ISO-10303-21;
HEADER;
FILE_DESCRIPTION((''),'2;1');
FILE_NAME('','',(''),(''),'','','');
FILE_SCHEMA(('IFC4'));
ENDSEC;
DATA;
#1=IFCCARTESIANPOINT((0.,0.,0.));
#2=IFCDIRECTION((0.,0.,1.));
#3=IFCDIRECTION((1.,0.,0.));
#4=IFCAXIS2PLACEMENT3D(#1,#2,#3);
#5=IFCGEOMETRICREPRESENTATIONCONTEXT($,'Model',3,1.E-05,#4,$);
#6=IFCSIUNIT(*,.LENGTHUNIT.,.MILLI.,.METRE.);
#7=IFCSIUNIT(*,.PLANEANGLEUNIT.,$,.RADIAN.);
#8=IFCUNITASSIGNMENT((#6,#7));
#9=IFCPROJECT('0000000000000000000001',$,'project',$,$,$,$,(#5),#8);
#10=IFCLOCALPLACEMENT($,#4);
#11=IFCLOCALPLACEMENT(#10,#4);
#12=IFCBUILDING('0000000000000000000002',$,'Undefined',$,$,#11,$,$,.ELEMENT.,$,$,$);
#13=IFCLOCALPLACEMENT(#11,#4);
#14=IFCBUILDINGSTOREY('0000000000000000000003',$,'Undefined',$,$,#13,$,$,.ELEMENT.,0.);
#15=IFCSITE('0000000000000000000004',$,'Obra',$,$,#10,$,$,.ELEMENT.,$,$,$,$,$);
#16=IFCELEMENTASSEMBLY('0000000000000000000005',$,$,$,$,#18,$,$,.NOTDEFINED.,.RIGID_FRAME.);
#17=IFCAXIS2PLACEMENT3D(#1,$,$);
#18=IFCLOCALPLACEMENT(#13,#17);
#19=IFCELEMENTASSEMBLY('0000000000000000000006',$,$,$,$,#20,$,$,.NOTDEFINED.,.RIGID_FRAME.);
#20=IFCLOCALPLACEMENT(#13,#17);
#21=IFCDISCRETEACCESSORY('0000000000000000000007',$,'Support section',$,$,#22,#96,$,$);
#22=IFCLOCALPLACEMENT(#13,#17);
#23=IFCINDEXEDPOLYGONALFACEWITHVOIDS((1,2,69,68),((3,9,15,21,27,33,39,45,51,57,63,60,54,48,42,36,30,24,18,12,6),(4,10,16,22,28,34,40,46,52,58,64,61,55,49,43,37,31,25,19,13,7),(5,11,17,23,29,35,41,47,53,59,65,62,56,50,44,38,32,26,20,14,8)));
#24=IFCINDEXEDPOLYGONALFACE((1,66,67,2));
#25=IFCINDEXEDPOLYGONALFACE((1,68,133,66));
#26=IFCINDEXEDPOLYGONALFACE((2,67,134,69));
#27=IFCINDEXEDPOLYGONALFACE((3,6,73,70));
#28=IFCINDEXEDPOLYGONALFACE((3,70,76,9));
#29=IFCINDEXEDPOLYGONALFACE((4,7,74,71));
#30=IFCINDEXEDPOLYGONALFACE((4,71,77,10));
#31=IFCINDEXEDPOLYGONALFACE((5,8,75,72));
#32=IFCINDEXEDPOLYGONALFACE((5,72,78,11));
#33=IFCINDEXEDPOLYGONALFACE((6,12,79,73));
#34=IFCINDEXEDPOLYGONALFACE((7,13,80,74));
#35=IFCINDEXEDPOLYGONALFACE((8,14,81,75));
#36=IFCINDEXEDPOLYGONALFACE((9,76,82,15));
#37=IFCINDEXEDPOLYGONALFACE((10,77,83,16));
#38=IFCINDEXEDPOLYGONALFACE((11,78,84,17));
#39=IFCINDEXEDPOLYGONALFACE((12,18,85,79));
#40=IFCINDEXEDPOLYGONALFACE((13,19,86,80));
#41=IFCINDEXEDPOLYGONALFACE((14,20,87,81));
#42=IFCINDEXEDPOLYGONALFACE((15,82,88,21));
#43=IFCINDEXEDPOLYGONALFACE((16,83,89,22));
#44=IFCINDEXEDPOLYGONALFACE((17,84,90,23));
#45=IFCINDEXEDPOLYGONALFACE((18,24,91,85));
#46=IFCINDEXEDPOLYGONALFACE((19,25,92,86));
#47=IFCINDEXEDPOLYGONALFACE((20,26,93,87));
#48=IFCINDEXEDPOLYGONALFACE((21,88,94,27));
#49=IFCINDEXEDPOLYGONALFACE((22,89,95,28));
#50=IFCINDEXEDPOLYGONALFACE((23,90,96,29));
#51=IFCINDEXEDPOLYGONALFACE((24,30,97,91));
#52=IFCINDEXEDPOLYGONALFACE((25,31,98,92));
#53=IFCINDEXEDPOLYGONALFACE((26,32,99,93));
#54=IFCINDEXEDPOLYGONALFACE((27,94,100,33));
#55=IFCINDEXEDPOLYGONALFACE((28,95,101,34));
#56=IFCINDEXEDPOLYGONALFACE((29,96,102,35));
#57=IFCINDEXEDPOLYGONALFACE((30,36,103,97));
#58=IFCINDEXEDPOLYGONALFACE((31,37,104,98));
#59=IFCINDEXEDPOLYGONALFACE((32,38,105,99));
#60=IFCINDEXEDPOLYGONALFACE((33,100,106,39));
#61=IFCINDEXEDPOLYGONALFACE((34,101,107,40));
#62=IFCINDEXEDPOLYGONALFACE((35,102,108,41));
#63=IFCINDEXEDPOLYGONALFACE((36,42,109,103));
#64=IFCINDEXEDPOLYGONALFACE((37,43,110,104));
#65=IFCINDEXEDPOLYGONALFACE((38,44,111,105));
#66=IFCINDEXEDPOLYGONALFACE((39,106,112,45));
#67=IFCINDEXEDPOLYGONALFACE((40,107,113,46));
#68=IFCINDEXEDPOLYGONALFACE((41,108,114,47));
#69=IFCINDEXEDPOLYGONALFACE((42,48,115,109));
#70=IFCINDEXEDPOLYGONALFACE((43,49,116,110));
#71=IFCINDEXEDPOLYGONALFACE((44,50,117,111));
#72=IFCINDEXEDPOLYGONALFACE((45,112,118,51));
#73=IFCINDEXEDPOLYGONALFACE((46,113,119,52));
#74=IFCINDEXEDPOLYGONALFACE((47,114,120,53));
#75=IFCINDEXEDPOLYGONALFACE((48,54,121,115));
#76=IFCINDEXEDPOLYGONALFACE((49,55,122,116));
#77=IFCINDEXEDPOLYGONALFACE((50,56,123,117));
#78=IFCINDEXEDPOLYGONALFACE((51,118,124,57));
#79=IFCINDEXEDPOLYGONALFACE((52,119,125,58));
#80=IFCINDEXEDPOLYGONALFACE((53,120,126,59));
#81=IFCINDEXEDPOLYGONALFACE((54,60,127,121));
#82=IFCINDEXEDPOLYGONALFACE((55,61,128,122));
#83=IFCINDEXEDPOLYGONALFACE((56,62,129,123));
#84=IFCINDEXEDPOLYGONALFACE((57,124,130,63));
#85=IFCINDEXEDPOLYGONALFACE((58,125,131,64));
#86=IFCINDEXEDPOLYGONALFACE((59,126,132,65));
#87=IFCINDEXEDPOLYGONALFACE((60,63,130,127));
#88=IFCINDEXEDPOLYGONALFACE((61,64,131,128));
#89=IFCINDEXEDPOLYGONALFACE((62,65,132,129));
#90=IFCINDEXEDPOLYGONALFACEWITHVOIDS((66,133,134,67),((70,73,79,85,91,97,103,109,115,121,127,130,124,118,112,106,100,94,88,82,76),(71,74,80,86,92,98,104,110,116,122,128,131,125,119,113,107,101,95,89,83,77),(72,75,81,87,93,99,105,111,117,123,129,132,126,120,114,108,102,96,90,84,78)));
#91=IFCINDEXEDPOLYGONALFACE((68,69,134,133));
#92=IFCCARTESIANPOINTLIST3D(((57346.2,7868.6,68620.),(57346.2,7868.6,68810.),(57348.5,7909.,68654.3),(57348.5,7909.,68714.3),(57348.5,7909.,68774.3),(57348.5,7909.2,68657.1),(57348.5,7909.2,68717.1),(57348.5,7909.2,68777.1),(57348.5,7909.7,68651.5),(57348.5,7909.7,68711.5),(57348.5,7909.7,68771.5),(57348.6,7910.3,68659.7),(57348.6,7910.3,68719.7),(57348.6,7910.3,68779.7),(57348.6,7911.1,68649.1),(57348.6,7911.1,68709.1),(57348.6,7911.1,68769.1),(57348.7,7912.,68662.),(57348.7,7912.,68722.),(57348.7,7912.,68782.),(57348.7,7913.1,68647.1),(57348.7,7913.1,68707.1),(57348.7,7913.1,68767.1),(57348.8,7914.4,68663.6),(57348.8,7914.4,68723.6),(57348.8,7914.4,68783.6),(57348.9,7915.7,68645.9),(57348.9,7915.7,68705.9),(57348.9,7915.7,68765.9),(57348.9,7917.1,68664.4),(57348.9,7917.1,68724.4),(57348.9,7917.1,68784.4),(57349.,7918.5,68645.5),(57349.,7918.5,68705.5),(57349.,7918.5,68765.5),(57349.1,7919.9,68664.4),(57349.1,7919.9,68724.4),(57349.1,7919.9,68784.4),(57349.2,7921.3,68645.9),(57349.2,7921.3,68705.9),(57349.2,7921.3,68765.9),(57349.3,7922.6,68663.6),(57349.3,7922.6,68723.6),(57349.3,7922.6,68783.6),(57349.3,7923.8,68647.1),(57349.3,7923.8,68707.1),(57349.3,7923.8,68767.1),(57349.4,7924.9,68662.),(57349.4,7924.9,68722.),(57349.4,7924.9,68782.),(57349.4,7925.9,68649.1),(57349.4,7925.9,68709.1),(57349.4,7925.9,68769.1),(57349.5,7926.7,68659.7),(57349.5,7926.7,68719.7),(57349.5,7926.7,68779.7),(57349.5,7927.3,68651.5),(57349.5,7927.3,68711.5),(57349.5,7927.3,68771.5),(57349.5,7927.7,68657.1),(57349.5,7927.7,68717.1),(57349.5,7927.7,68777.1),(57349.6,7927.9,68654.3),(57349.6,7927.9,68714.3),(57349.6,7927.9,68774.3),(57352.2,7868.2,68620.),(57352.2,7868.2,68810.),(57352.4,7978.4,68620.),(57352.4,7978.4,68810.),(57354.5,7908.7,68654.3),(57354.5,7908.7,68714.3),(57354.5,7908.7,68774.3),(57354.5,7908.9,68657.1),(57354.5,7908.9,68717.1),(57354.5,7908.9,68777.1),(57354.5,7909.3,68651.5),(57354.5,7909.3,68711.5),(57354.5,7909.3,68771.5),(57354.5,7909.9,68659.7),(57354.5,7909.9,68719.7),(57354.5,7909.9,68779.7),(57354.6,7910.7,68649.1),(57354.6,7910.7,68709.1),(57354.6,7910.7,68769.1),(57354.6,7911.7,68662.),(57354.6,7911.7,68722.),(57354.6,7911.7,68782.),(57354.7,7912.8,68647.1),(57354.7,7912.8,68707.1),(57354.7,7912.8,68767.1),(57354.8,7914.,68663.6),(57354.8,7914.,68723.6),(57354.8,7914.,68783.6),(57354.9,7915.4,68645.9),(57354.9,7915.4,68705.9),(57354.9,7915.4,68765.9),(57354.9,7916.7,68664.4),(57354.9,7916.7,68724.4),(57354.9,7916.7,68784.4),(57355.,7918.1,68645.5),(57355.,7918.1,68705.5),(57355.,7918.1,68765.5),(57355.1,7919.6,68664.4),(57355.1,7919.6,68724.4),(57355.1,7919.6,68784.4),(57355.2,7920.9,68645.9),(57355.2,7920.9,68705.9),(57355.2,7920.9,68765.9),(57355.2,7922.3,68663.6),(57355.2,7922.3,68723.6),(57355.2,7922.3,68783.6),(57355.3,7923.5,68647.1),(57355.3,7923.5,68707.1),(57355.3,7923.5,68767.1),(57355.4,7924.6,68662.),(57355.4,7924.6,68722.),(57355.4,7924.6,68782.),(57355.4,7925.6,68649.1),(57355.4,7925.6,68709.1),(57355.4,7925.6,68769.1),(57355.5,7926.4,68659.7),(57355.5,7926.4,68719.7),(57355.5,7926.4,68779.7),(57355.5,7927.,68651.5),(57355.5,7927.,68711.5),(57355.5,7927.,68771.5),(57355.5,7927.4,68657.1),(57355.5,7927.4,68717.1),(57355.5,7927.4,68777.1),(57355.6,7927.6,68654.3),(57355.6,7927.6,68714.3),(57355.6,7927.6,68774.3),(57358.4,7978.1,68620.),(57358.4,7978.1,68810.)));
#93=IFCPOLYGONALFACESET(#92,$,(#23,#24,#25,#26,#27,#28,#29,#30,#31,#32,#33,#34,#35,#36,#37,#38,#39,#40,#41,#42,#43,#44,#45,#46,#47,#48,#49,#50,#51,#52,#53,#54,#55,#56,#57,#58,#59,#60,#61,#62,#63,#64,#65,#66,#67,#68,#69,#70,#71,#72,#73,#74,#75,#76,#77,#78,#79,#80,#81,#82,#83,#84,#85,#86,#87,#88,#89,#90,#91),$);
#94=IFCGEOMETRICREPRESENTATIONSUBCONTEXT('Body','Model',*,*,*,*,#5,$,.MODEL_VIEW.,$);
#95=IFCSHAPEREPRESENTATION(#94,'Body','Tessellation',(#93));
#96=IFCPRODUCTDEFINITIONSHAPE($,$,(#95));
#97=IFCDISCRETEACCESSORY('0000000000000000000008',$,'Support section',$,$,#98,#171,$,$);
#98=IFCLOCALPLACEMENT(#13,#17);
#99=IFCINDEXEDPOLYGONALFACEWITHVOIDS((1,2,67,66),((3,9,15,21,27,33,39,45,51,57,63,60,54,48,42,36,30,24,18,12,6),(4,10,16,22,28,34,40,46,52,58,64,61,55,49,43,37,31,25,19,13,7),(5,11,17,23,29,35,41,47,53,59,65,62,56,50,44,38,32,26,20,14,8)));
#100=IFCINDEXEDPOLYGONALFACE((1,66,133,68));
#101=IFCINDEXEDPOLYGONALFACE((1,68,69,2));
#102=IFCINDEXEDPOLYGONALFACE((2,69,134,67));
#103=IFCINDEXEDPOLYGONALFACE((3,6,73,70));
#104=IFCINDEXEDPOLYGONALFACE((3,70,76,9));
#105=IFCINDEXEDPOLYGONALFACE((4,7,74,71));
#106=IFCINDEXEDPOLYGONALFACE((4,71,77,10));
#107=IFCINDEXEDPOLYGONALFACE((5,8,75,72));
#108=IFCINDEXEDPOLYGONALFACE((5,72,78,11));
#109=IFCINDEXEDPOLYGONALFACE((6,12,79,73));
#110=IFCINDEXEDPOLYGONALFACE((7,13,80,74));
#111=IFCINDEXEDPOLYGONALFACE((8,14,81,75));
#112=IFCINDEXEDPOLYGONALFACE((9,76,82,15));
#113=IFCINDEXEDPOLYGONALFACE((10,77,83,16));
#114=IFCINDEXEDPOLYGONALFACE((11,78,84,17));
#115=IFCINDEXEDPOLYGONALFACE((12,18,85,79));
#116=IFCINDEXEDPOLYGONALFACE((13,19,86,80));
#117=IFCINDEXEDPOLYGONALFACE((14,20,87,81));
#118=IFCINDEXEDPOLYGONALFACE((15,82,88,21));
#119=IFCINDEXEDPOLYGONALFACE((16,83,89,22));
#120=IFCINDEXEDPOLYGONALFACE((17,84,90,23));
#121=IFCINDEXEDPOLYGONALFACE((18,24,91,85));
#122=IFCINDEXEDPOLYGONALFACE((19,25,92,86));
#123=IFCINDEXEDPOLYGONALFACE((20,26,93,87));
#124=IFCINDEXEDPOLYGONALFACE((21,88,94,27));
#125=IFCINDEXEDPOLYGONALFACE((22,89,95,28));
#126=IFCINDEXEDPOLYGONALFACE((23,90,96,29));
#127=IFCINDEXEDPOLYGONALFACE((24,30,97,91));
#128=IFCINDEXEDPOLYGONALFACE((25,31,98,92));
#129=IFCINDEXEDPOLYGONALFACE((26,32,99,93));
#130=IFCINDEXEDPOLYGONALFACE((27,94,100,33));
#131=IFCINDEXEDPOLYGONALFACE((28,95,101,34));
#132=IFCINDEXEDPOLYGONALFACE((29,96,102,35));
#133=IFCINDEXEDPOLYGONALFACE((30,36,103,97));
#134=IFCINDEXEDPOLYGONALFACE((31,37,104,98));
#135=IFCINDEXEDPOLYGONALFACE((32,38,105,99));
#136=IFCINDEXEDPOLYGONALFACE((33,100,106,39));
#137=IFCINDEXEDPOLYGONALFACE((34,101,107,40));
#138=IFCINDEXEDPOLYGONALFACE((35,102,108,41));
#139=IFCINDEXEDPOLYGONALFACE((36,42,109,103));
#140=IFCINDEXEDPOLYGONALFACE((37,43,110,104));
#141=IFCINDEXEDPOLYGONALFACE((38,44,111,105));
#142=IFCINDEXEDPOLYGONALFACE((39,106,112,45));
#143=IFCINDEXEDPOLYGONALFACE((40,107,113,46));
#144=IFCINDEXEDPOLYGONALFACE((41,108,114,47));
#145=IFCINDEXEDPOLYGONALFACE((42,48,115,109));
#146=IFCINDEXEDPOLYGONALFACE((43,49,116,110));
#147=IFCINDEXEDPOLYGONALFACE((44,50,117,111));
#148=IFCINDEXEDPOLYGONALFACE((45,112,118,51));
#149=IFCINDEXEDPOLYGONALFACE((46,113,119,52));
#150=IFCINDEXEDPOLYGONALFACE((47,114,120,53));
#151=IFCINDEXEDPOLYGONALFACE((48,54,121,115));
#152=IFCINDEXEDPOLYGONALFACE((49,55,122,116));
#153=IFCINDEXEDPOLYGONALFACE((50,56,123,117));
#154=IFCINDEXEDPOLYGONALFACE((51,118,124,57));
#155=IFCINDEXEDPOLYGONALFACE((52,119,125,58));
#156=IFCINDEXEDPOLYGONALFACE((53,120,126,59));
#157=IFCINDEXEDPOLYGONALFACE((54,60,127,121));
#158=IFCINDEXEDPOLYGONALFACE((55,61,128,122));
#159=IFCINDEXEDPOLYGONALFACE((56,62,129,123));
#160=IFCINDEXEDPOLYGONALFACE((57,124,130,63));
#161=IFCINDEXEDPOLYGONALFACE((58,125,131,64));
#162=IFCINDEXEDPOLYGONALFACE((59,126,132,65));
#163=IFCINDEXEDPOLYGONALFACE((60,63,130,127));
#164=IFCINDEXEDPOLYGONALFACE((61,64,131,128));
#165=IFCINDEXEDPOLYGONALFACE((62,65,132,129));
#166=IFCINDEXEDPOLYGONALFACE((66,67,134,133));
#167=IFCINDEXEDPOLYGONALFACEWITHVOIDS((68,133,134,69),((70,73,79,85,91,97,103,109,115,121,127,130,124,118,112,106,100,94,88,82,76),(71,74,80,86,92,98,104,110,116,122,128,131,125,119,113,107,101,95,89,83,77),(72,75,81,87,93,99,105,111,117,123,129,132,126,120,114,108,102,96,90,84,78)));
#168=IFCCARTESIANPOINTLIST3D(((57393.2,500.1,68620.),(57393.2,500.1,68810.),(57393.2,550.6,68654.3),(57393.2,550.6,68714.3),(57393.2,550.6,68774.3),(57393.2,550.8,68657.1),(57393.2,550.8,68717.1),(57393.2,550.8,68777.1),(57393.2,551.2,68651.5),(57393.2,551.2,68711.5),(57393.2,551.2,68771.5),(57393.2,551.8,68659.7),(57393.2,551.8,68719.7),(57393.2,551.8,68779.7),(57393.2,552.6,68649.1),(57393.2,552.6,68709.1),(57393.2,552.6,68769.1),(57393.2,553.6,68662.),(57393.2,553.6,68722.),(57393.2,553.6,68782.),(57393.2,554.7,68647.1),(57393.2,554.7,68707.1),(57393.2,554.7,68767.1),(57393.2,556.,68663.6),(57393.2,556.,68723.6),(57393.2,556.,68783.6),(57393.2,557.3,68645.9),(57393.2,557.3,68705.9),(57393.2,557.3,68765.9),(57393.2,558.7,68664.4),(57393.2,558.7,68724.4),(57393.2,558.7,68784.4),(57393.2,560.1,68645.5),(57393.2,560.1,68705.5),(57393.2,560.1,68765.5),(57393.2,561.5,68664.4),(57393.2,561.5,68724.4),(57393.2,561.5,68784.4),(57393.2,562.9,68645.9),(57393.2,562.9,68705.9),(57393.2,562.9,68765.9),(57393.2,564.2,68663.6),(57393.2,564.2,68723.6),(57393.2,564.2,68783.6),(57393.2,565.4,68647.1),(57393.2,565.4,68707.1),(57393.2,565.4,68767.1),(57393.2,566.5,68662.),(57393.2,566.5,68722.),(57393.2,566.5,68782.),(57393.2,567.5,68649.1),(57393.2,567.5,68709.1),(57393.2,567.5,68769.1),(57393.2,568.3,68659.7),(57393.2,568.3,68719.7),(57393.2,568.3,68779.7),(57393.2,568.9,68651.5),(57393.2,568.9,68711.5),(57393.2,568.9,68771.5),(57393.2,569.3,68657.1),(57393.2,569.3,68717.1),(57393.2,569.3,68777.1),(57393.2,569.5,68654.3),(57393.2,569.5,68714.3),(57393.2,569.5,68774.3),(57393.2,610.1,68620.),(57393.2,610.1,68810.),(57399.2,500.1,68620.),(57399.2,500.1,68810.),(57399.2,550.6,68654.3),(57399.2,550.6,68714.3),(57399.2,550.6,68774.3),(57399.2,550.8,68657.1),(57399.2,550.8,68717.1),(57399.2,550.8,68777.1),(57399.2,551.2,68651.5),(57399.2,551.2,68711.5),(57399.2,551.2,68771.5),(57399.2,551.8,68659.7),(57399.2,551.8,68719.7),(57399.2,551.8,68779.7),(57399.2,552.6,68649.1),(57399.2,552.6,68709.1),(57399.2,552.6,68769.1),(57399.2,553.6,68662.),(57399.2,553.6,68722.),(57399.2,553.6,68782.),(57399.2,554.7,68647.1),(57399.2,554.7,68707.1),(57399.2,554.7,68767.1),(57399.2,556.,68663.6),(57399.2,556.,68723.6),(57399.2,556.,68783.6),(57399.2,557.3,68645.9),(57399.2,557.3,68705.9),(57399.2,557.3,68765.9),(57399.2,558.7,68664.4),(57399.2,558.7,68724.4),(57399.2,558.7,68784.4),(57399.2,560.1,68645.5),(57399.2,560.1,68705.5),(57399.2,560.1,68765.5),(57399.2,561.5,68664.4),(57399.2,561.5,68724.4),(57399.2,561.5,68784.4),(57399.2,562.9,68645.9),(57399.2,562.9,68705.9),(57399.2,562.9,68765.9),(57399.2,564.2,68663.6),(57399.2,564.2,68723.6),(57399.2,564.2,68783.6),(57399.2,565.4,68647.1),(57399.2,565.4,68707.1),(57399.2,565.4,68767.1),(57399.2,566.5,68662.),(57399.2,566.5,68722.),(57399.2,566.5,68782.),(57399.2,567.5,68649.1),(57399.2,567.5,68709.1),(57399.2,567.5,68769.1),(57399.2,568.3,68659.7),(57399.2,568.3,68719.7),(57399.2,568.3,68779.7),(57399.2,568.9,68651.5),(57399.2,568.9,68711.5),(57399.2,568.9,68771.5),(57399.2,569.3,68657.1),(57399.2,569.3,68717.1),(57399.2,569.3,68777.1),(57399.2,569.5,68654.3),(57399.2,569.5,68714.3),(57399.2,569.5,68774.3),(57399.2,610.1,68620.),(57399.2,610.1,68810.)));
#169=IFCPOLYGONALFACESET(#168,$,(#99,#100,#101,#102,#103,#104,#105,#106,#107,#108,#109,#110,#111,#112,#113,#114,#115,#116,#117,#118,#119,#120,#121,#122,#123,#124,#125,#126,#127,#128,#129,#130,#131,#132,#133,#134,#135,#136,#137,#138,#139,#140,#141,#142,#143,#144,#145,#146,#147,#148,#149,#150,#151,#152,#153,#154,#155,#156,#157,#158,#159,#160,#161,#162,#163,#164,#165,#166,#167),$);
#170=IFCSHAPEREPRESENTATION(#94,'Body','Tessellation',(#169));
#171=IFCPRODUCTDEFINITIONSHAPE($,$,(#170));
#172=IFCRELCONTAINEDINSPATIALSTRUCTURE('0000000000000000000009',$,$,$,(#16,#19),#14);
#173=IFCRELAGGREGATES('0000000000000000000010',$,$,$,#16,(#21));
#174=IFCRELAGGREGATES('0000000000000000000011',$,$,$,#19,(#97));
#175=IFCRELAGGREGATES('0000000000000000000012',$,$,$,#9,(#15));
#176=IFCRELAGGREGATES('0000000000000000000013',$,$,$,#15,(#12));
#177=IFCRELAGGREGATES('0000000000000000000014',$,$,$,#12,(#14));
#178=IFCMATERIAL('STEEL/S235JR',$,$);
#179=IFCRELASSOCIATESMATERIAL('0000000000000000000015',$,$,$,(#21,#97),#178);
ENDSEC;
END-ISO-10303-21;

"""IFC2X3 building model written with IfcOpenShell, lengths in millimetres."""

from ifc_helpers import new_model, si_unit, frame, origin_with_axes, origin_2d_with_axis, place, context, subcontext, project, spatial, rectangle, circle, extrude, source, transform, mapped, material, element, aggregate, save


model = new_model("IFC2X3")

# Units and contexts
model_context = context("Model", 3, precision=1e-05, world=origin_with_axes())
body_context = subcontext(model_context, "Body", "Model", "MODEL_VIEW")
ifc_project = project(units=[si_unit("LENGTHUNIT", "METRE", prefix="MILLI"), si_unit("PLANEANGLEUNIT", "RADIAN")], contexts=[model_context])

# Site, building, storey
site_placement = place(None, origin_with_axes())
site = spatial("IfcSite", under=ifc_project, at=site_placement, Name="Obra", CompositionType="ELEMENT")
building_placement = place(site_placement, origin_with_axes())
building = spatial("IfcBuilding", under=site, at=building_placement, Name="Undefined", CompositionType="ELEMENT")
storey_placement = place(building_placement, origin_with_axes())
storey = spatial("IfcBuildingStorey", under=building, at=storey_placement, Name="Undefined", CompositionType="ELEMENT", Elevation=0.0)

# Element assemblies
ifc_material_1 = material(Name="STEEL/S235JR")
assembly_1_placement = place(storey_placement, origin_with_axes())
assembly_1 = element("IfcElementAssembly", 1, at=assembly_1_placement, inside=storey, AssemblyPlace="NOTDEFINED", PredefinedType="RIGID_FRAME")
assembly_2_placement = place(storey_placement, origin_with_axes())
assembly_2 = element("IfcElementAssembly", 2, at=assembly_2_placement, inside=storey, AssemblyPlace="NOTDEFINED", PredefinedType="RIGID_FRAME")

# Shared definitions
shared_shape_1 = source(origin_with_axes(), body_context, "Body", "SweptSolid", [
    extrude(circle(Radius=9.5, at=origin_2d_with_axis()), frame((0.0, -9.2, 0.0), z_axis=(0.0, 1.0, 0.0), x_axis=(1.0, 0.0, 0.0)), (0.0, 0.0, 1.0), 6.2),
])

# Discrete accessories, openings
discrete_accessory_1_placement = place(assembly_1_placement, frame((57352.3, 7923.3, 68620.0), z_axis=(0.0, 0.0, 1.0), x_axis=(0.05711, 0.998368, 0.0)))
discrete_accessory_1 = element("IfcDiscreteAccessory", 3, at=discrete_accessory_1_placement, material=ifc_material_1, Name="Support section", context=body_context, shape_type="SweptSolid", body=[
    extrude(rectangle(XDim=6.0, YDim=110.0, at=origin_2d_with_axis()), frame((0.0, 0.0, 190.0), z_axis=(0.0, 0.0, -1.0), x_axis=(0.0, 1.0, 0.0)), (0.0, 0.0, 1.0), 190.0),
])
opening_1_placement = place(assembly_1_placement, frame((57361.0, 7967.9, 68835.0), z_axis=(-0.05711, -0.998368, 0.0), x_axis=(0.0, 0.0, -1.0)))
element("IfcOpeningElement", 4, at=opening_1_placement, cuts=discrete_accessory_1, ObjectType="Opening", context=body_context, shape_type="MappedRepresentation", body=[
    mapped(shared_shape_1, transform((60.0, 0.0, 50.0))),
    mapped(shared_shape_1, transform((120.0, 0.0, 50.0))),
    mapped(shared_shape_1, transform((180.0, 0.0, 50.0))),
])
aggregate(assembly_1, [discrete_accessory_1])
discrete_accessory_2_placement = place(assembly_2_placement, frame((57396.2, 555.1, 68620.0), z_axis=(0.0, 0.0, 1.0), x_axis=(0.000002, -1.0, 0.0)))
discrete_accessory_2 = element("IfcDiscreteAccessory", 5, at=discrete_accessory_2_placement, material=ifc_material_1, Name="Support section", context=body_context, shape_type="SweptSolid", body=[
    extrude(rectangle(XDim=6.0, YDim=110.0, at=origin_2d_with_axis()), frame((0.0, 0.0, 190.0), z_axis=(0.0, 0.0, -1.0), x_axis=(0.0, 1.0, 0.0)), (0.0, 0.0, 1.0), 190.0),
])
opening_2_placement = place(assembly_2_placement, frame((57390.1, 510.1, 68835.0), z_axis=(-0.000002, 1.0, 0.0), x_axis=(0.0, 0.0, -1.0)))
element("IfcOpeningElement", 6, at=opening_2_placement, cuts=discrete_accessory_2, ObjectType="Opening", context=body_context, shape_type="MappedRepresentation", body=[
    mapped(shared_shape_1, transform((60.0, 0.0, 50.0))),
    mapped(shared_shape_1, transform((120.0, 0.0, 50.0))),
    mapped(shared_shape_1, transform((180.0, 0.0, 50.0))),
])
aggregate(assembly_2, [discrete_accessory_2])

save(model, "model.ifc")
